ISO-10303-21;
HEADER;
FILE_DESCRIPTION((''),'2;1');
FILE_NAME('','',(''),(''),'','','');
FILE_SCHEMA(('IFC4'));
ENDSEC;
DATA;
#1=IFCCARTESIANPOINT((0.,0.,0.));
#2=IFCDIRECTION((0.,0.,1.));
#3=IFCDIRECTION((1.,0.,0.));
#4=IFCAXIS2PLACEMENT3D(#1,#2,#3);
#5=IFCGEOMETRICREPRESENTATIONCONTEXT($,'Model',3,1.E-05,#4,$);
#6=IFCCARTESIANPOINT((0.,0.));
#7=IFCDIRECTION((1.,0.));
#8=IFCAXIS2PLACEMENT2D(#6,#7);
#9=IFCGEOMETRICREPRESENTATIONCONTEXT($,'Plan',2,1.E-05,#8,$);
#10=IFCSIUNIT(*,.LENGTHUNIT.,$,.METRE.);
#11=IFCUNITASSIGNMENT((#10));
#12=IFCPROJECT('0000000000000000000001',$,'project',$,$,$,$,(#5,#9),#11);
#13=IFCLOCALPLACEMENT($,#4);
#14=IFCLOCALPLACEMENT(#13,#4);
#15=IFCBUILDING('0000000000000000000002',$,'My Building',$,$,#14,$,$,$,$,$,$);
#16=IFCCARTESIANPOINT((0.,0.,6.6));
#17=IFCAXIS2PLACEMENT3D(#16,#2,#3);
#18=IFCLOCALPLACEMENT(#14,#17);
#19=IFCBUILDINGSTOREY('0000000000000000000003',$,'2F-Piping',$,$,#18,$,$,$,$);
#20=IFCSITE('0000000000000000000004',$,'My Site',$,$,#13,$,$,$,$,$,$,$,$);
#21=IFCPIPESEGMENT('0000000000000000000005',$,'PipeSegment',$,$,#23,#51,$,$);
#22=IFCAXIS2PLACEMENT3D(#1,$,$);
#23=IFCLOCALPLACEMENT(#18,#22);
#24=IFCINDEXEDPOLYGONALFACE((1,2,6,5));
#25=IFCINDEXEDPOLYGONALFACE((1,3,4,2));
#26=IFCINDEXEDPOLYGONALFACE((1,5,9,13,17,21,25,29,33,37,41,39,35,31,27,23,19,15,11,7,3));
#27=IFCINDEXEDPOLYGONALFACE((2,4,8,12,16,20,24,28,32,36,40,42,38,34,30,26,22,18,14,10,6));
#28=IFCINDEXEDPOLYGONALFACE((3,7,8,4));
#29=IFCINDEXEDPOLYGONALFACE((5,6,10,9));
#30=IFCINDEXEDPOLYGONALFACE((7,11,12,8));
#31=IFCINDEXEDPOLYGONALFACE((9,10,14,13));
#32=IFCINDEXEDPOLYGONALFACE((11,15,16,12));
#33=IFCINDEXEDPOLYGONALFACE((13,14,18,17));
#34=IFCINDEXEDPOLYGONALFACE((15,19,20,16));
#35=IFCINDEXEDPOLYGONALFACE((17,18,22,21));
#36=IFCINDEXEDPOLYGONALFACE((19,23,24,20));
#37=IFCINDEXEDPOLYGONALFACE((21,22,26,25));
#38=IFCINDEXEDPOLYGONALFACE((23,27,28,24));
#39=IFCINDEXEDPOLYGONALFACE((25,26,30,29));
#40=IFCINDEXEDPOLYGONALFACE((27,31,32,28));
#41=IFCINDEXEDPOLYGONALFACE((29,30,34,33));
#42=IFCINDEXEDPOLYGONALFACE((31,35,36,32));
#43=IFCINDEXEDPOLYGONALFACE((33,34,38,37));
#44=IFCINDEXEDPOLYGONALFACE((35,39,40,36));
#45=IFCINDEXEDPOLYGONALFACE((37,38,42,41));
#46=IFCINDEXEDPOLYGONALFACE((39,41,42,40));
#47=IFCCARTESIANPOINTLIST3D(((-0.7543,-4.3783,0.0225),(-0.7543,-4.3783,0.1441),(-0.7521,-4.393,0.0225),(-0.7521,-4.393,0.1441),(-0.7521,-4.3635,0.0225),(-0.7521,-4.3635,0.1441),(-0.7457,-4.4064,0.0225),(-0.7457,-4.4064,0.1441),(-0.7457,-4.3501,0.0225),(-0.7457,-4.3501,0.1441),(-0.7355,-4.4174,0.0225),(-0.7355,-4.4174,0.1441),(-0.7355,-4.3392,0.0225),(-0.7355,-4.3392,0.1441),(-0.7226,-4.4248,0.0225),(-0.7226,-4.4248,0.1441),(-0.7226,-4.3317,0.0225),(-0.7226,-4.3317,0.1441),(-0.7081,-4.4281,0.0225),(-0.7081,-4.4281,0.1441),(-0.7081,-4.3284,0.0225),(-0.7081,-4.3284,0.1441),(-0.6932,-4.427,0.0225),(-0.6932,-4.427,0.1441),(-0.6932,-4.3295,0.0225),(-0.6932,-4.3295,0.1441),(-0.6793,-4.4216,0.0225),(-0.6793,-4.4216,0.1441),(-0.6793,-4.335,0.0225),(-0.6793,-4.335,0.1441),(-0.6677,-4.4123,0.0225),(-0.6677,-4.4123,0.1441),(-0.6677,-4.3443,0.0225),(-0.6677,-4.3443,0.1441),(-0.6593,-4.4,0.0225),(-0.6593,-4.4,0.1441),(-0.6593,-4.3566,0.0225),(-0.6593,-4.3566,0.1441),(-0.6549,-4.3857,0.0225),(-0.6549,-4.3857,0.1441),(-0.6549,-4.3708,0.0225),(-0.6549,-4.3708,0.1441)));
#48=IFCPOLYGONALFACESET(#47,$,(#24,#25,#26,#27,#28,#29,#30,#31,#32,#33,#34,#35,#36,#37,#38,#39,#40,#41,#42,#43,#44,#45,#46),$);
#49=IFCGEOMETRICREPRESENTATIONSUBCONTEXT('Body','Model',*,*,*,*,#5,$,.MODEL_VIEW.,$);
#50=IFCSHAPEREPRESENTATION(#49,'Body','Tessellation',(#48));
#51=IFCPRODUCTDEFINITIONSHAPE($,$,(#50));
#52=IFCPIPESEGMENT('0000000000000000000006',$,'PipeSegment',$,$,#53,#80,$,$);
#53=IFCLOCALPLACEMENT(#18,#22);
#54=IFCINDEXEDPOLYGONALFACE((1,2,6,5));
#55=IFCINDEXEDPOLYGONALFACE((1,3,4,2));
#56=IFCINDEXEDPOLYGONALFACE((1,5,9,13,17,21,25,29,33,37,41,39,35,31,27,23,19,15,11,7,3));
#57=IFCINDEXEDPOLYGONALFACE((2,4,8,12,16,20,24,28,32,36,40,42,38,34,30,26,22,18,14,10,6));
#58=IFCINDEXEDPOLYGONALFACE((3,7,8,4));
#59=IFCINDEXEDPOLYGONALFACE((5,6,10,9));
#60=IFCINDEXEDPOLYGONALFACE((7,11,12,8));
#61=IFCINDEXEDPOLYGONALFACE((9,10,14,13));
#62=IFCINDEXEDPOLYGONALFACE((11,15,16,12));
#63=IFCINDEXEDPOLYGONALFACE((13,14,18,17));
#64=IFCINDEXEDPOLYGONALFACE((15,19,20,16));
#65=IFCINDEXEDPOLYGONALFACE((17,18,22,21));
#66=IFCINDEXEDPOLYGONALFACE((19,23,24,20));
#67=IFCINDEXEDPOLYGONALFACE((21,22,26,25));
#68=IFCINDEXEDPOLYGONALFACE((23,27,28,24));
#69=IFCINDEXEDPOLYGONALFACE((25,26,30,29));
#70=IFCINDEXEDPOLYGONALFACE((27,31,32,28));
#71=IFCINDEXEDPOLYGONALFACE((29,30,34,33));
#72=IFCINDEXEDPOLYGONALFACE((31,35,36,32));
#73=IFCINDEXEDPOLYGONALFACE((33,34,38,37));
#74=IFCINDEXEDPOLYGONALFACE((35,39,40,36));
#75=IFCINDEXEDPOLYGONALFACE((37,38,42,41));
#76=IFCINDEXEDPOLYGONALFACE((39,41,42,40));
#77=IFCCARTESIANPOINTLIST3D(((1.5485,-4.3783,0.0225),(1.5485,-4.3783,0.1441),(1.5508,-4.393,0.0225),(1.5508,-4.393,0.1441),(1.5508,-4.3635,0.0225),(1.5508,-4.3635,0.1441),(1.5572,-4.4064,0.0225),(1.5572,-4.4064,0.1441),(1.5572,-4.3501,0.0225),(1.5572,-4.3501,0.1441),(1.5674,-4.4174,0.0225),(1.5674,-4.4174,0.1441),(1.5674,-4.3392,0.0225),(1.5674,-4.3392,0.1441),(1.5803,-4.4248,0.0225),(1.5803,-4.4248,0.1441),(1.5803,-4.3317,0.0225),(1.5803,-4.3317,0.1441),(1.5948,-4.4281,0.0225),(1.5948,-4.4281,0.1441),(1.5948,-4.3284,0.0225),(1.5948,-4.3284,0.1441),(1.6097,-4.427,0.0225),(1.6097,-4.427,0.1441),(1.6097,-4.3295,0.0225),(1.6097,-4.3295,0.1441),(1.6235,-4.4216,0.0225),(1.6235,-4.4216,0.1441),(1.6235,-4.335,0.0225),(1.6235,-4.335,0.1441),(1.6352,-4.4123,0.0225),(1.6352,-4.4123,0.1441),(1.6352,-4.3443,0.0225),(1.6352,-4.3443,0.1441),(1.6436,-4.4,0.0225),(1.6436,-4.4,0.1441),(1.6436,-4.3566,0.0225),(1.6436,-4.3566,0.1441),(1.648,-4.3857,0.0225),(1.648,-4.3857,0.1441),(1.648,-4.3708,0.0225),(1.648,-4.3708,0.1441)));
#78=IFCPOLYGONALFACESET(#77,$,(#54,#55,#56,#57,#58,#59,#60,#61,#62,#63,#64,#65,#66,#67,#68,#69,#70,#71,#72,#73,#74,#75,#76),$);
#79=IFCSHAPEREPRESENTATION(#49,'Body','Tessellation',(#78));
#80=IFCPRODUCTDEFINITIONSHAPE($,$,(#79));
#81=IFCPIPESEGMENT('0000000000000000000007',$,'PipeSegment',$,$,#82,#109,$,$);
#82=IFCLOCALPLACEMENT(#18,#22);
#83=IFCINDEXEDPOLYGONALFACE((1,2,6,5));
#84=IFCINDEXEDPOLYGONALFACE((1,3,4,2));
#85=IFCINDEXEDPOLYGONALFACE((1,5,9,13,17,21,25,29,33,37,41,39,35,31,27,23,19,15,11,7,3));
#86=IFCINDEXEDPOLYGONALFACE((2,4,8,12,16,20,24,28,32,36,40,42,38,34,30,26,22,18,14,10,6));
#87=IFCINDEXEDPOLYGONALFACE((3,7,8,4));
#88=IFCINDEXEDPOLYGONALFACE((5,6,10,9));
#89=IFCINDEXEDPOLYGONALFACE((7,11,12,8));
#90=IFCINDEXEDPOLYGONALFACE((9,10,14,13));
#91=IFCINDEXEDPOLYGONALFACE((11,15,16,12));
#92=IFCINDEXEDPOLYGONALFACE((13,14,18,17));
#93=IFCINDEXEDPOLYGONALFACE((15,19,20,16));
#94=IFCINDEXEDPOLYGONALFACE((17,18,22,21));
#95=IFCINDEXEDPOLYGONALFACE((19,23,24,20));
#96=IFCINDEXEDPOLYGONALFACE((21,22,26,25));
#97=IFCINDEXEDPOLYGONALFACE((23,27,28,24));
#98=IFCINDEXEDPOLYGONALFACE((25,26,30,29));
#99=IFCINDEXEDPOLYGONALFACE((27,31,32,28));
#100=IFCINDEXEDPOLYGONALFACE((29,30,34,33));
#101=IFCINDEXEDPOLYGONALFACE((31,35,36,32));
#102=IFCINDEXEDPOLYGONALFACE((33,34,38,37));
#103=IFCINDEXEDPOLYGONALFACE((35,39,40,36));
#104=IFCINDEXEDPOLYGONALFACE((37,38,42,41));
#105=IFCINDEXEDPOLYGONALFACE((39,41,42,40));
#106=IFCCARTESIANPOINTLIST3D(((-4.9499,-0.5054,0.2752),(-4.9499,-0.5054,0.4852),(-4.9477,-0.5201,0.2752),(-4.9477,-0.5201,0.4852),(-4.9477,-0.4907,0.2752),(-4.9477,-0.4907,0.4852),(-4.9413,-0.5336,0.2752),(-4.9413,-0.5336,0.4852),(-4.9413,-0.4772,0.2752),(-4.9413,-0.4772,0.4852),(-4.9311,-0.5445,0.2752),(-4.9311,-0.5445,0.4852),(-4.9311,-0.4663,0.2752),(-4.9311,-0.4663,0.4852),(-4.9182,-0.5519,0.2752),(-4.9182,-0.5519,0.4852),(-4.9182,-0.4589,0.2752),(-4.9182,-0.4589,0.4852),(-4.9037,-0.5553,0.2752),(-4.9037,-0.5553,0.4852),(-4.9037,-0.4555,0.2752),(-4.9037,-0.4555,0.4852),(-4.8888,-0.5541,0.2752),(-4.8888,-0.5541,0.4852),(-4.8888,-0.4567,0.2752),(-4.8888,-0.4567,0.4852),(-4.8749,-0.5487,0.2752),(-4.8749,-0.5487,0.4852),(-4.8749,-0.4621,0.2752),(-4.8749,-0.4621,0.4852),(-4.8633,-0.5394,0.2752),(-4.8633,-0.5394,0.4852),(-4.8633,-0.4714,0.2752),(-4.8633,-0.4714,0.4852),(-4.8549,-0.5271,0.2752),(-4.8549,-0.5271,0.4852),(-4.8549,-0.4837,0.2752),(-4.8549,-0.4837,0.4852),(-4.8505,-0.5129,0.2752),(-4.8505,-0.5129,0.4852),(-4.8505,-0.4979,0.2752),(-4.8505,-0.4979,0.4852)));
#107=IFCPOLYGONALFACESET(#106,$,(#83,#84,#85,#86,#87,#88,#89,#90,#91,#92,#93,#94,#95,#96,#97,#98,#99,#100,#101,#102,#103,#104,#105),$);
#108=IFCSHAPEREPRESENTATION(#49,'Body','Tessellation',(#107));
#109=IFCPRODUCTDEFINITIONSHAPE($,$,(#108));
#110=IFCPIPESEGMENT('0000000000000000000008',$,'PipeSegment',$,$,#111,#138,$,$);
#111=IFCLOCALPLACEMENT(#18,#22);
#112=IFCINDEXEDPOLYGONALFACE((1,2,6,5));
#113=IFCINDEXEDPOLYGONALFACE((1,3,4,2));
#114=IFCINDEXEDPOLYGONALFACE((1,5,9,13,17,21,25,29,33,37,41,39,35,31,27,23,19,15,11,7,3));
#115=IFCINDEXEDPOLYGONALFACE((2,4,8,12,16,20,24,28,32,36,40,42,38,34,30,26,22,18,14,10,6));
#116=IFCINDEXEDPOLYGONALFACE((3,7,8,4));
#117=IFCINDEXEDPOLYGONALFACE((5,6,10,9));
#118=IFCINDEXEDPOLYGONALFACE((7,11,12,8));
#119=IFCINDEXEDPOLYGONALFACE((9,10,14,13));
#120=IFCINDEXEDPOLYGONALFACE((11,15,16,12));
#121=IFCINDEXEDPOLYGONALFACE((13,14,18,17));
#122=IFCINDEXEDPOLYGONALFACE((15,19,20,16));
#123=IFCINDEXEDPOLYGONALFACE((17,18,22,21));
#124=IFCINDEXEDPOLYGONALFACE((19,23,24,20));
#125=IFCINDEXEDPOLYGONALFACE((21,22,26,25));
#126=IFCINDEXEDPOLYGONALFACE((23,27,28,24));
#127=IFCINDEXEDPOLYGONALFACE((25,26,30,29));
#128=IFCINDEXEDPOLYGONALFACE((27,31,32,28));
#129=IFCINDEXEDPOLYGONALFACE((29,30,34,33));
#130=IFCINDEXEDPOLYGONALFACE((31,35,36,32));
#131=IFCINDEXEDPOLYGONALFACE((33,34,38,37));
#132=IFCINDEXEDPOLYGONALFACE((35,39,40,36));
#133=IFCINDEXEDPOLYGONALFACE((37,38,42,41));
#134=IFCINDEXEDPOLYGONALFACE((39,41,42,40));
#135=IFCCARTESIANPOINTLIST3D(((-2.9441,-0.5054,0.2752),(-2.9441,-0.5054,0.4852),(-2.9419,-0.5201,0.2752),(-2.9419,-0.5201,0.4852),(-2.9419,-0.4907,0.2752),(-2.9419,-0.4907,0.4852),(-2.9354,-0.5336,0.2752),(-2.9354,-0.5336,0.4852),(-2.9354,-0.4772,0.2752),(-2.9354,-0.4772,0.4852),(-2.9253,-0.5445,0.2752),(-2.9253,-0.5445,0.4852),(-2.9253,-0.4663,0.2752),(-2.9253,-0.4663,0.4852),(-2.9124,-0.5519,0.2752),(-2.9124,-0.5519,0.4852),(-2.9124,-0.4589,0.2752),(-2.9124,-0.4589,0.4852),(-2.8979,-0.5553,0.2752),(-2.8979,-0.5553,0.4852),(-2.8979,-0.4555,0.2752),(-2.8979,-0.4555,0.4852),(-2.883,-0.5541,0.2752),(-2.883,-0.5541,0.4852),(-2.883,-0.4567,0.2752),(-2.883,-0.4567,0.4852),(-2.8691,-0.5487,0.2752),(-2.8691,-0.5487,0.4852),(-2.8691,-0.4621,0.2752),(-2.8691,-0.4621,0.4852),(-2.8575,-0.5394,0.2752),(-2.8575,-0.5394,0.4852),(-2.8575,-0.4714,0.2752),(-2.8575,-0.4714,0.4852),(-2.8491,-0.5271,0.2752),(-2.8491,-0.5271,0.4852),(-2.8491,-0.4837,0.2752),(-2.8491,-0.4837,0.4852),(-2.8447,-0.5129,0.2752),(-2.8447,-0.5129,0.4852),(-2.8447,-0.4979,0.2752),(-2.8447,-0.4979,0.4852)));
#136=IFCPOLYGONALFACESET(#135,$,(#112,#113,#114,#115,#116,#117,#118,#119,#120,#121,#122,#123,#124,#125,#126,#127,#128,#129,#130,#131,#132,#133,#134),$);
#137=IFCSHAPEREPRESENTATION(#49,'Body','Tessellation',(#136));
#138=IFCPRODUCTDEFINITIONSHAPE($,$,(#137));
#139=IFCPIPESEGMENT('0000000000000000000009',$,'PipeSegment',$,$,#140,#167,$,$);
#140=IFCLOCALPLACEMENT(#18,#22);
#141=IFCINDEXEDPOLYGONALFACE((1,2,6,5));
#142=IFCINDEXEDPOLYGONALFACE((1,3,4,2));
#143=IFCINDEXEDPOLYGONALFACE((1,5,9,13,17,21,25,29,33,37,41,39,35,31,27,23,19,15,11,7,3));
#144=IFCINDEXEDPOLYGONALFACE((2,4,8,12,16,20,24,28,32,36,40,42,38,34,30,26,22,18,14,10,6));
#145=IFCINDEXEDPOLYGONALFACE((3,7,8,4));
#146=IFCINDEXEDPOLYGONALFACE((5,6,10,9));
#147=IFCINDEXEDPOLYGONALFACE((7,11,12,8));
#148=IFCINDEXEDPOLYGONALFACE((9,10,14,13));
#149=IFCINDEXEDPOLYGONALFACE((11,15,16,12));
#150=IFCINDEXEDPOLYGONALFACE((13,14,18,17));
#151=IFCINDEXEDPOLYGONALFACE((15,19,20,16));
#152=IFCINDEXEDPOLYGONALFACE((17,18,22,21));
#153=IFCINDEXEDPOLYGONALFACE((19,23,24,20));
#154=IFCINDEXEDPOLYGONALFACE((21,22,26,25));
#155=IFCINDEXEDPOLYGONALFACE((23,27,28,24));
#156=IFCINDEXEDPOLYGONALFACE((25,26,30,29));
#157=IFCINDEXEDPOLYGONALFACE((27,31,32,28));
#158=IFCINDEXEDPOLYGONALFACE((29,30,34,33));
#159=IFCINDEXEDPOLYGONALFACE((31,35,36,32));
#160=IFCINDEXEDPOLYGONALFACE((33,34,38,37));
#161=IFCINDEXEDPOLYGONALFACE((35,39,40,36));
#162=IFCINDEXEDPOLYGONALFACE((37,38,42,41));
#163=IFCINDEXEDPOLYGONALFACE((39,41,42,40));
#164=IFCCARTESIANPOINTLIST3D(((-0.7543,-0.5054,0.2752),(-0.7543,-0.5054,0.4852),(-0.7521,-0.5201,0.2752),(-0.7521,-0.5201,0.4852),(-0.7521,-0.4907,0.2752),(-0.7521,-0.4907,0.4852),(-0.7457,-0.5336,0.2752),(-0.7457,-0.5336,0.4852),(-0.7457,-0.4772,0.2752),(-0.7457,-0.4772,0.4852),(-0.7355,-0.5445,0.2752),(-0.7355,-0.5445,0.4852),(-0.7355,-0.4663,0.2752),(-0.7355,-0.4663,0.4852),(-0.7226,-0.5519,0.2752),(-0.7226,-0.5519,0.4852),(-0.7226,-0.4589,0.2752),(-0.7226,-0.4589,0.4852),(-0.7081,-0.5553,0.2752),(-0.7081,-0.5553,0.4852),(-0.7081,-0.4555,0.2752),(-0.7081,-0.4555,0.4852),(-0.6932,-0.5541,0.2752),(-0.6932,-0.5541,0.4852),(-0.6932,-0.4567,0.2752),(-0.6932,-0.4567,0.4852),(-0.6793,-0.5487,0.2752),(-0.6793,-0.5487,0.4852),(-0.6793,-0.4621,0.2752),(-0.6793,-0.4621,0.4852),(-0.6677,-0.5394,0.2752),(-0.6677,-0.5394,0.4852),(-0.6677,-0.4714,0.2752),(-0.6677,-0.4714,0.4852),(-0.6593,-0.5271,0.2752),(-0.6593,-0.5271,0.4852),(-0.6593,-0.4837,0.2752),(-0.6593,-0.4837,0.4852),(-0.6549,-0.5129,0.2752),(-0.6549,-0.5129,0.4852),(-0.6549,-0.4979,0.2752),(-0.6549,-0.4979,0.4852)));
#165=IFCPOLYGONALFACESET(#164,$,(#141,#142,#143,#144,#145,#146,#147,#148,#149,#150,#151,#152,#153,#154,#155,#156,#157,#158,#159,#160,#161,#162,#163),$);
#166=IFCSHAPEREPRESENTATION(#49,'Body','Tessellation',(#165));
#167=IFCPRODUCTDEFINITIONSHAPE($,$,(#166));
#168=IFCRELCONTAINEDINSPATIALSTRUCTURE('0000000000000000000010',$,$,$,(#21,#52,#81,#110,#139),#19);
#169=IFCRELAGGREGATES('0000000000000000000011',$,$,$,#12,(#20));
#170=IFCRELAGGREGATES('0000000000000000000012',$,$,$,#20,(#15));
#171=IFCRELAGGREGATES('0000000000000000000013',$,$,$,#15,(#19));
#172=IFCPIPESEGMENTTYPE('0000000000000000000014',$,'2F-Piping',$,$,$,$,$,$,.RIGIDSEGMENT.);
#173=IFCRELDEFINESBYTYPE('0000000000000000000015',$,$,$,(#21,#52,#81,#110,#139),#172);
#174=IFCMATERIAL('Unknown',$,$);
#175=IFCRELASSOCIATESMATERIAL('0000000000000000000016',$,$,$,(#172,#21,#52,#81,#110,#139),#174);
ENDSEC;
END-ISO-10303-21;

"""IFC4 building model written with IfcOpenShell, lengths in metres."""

from ifc_helpers import new_model, si_unit, frame, origin_with_axes, origin_2d_with_axis, place, context, subcontext, project, spatial, circle, extrude, material, material_profile, profile_set, profile_usage, type_object, element, save


model = new_model("IFC4")

# Units and contexts
model_context = context("Model", 3, precision=1e-05, world=origin_with_axes())
plan_context = context("Plan", 2, precision=1e-05, world=origin_2d_with_axis())
body_context = subcontext(model_context, "Body", "Model", "MODEL_VIEW")
ifc_project = project(units=[si_unit("LENGTHUNIT", "METRE")], contexts=[model_context, plan_context])

# Site, building, storey
site_placement = place(None, origin_with_axes())
site = spatial("IfcSite", under=ifc_project, at=site_placement, Name="My Site")
building_placement = place(site_placement, origin_with_axes())
building = spatial("IfcBuilding", under=site, at=building_placement, Name="My Building")
storey_placement = place(building_placement, frame((0.0, 0.0, 6.6), z_axis=(0.0, 0.0, 1.0), x_axis=(1.0, 0.0, 0.0)))
storey = spatial("IfcBuildingStorey", under=building, at=storey_placement, Name="2F-Piping")

# Pipe segments
ifc_material = material(Name="Unknown")
ifc_material_profile = material_profile(ifc_material, circle(Radius=0.05))
ifc_profile_set = profile_set([ifc_material_profile])
pipe_segment_type = type_object("IfcPipeSegmentType", Name="2F-Piping", PredefinedType="RIGIDSEGMENT", material=ifc_profile_set)
ifc_profile_usage_1 = profile_usage(ifc_profile_set, cardinal=5)
pipe_segment_1_placement = place(storey_placement, frame((-0.7043, -4.3783, 0.1441), z_axis=(0.0, 0.0, -1.0), x_axis=(-1.0, 0.0, 0.0)))
element("IfcPipeSegment", 1, at=pipe_segment_1_placement, inside=storey, type_object=pipe_segment_type, material=ifc_profile_usage_1, Name="PipeSegment", context=body_context, shape_type="SweptSolid", body=[
    extrude(circle(Radius=0.05), origin_with_axes(), (0.0, 0.0, 1.0), 0.1217),
])
ifc_profile_usage_2 = profile_usage(ifc_profile_set, cardinal=5)
pipe_segment_2_placement = place(storey_placement, frame((1.5985, -4.3783, 0.1441), z_axis=(0.0, 0.0, -1.0), x_axis=(-1.0, 0.0, 0.0)))
element("IfcPipeSegment", 2, at=pipe_segment_2_placement, inside=storey, type_object=pipe_segment_type, material=ifc_profile_usage_2, Name="PipeSegment", context=body_context, shape_type="SweptSolid", body=[
    extrude(circle(Radius=0.05), origin_with_axes(), (0.0, 0.0, 1.0), 0.1217),
])
ifc_profile_usage_3 = profile_usage(ifc_profile_set, cardinal=5)
pipe_segment_3_placement = place(storey_placement, frame((-4.8999, -0.5054, 0.4852), z_axis=(0.0, 0.0, -1.0), x_axis=(-1.0, 0.0, 0.0)))
element("IfcPipeSegment", 3, at=pipe_segment_3_placement, inside=storey, type_object=pipe_segment_type, material=ifc_profile_usage_3, Name="PipeSegment", context=body_context, shape_type="SweptSolid", body=[
    extrude(circle(Radius=0.05), origin_with_axes(), (0.0, 0.0, 1.0), 0.21),
])
ifc_profile_usage_4 = profile_usage(ifc_profile_set, cardinal=5)
pipe_segment_4_placement = place(storey_placement, frame((-2.8941, -0.5054, 0.4852), z_axis=(0.0, 0.0, -1.0), x_axis=(-1.0, 0.0, 0.0)))
element("IfcPipeSegment", 4, at=pipe_segment_4_placement, inside=storey, type_object=pipe_segment_type, material=ifc_profile_usage_4, Name="PipeSegment", context=body_context, shape_type="SweptSolid", body=[
    extrude(circle(Radius=0.05), origin_with_axes(), (0.0, 0.0, 1.0), 0.21),
])
ifc_profile_usage_5 = profile_usage(ifc_profile_set, cardinal=5)
pipe_segment_5_placement = place(storey_placement, frame((-0.7043, -0.5054, 0.4852), z_axis=(0.0, 0.0, -1.0), x_axis=(-1.0, 0.0, 0.0)))
element("IfcPipeSegment", 5, at=pipe_segment_5_placement, inside=storey, type_object=pipe_segment_type, material=ifc_profile_usage_5, Name="PipeSegment", context=body_context, shape_type="SweptSolid", body=[
    extrude(circle(Radius=0.05), origin_with_axes(), (0.0, 0.0, 1.0), 0.21),
])

save(model, "model.ifc")
